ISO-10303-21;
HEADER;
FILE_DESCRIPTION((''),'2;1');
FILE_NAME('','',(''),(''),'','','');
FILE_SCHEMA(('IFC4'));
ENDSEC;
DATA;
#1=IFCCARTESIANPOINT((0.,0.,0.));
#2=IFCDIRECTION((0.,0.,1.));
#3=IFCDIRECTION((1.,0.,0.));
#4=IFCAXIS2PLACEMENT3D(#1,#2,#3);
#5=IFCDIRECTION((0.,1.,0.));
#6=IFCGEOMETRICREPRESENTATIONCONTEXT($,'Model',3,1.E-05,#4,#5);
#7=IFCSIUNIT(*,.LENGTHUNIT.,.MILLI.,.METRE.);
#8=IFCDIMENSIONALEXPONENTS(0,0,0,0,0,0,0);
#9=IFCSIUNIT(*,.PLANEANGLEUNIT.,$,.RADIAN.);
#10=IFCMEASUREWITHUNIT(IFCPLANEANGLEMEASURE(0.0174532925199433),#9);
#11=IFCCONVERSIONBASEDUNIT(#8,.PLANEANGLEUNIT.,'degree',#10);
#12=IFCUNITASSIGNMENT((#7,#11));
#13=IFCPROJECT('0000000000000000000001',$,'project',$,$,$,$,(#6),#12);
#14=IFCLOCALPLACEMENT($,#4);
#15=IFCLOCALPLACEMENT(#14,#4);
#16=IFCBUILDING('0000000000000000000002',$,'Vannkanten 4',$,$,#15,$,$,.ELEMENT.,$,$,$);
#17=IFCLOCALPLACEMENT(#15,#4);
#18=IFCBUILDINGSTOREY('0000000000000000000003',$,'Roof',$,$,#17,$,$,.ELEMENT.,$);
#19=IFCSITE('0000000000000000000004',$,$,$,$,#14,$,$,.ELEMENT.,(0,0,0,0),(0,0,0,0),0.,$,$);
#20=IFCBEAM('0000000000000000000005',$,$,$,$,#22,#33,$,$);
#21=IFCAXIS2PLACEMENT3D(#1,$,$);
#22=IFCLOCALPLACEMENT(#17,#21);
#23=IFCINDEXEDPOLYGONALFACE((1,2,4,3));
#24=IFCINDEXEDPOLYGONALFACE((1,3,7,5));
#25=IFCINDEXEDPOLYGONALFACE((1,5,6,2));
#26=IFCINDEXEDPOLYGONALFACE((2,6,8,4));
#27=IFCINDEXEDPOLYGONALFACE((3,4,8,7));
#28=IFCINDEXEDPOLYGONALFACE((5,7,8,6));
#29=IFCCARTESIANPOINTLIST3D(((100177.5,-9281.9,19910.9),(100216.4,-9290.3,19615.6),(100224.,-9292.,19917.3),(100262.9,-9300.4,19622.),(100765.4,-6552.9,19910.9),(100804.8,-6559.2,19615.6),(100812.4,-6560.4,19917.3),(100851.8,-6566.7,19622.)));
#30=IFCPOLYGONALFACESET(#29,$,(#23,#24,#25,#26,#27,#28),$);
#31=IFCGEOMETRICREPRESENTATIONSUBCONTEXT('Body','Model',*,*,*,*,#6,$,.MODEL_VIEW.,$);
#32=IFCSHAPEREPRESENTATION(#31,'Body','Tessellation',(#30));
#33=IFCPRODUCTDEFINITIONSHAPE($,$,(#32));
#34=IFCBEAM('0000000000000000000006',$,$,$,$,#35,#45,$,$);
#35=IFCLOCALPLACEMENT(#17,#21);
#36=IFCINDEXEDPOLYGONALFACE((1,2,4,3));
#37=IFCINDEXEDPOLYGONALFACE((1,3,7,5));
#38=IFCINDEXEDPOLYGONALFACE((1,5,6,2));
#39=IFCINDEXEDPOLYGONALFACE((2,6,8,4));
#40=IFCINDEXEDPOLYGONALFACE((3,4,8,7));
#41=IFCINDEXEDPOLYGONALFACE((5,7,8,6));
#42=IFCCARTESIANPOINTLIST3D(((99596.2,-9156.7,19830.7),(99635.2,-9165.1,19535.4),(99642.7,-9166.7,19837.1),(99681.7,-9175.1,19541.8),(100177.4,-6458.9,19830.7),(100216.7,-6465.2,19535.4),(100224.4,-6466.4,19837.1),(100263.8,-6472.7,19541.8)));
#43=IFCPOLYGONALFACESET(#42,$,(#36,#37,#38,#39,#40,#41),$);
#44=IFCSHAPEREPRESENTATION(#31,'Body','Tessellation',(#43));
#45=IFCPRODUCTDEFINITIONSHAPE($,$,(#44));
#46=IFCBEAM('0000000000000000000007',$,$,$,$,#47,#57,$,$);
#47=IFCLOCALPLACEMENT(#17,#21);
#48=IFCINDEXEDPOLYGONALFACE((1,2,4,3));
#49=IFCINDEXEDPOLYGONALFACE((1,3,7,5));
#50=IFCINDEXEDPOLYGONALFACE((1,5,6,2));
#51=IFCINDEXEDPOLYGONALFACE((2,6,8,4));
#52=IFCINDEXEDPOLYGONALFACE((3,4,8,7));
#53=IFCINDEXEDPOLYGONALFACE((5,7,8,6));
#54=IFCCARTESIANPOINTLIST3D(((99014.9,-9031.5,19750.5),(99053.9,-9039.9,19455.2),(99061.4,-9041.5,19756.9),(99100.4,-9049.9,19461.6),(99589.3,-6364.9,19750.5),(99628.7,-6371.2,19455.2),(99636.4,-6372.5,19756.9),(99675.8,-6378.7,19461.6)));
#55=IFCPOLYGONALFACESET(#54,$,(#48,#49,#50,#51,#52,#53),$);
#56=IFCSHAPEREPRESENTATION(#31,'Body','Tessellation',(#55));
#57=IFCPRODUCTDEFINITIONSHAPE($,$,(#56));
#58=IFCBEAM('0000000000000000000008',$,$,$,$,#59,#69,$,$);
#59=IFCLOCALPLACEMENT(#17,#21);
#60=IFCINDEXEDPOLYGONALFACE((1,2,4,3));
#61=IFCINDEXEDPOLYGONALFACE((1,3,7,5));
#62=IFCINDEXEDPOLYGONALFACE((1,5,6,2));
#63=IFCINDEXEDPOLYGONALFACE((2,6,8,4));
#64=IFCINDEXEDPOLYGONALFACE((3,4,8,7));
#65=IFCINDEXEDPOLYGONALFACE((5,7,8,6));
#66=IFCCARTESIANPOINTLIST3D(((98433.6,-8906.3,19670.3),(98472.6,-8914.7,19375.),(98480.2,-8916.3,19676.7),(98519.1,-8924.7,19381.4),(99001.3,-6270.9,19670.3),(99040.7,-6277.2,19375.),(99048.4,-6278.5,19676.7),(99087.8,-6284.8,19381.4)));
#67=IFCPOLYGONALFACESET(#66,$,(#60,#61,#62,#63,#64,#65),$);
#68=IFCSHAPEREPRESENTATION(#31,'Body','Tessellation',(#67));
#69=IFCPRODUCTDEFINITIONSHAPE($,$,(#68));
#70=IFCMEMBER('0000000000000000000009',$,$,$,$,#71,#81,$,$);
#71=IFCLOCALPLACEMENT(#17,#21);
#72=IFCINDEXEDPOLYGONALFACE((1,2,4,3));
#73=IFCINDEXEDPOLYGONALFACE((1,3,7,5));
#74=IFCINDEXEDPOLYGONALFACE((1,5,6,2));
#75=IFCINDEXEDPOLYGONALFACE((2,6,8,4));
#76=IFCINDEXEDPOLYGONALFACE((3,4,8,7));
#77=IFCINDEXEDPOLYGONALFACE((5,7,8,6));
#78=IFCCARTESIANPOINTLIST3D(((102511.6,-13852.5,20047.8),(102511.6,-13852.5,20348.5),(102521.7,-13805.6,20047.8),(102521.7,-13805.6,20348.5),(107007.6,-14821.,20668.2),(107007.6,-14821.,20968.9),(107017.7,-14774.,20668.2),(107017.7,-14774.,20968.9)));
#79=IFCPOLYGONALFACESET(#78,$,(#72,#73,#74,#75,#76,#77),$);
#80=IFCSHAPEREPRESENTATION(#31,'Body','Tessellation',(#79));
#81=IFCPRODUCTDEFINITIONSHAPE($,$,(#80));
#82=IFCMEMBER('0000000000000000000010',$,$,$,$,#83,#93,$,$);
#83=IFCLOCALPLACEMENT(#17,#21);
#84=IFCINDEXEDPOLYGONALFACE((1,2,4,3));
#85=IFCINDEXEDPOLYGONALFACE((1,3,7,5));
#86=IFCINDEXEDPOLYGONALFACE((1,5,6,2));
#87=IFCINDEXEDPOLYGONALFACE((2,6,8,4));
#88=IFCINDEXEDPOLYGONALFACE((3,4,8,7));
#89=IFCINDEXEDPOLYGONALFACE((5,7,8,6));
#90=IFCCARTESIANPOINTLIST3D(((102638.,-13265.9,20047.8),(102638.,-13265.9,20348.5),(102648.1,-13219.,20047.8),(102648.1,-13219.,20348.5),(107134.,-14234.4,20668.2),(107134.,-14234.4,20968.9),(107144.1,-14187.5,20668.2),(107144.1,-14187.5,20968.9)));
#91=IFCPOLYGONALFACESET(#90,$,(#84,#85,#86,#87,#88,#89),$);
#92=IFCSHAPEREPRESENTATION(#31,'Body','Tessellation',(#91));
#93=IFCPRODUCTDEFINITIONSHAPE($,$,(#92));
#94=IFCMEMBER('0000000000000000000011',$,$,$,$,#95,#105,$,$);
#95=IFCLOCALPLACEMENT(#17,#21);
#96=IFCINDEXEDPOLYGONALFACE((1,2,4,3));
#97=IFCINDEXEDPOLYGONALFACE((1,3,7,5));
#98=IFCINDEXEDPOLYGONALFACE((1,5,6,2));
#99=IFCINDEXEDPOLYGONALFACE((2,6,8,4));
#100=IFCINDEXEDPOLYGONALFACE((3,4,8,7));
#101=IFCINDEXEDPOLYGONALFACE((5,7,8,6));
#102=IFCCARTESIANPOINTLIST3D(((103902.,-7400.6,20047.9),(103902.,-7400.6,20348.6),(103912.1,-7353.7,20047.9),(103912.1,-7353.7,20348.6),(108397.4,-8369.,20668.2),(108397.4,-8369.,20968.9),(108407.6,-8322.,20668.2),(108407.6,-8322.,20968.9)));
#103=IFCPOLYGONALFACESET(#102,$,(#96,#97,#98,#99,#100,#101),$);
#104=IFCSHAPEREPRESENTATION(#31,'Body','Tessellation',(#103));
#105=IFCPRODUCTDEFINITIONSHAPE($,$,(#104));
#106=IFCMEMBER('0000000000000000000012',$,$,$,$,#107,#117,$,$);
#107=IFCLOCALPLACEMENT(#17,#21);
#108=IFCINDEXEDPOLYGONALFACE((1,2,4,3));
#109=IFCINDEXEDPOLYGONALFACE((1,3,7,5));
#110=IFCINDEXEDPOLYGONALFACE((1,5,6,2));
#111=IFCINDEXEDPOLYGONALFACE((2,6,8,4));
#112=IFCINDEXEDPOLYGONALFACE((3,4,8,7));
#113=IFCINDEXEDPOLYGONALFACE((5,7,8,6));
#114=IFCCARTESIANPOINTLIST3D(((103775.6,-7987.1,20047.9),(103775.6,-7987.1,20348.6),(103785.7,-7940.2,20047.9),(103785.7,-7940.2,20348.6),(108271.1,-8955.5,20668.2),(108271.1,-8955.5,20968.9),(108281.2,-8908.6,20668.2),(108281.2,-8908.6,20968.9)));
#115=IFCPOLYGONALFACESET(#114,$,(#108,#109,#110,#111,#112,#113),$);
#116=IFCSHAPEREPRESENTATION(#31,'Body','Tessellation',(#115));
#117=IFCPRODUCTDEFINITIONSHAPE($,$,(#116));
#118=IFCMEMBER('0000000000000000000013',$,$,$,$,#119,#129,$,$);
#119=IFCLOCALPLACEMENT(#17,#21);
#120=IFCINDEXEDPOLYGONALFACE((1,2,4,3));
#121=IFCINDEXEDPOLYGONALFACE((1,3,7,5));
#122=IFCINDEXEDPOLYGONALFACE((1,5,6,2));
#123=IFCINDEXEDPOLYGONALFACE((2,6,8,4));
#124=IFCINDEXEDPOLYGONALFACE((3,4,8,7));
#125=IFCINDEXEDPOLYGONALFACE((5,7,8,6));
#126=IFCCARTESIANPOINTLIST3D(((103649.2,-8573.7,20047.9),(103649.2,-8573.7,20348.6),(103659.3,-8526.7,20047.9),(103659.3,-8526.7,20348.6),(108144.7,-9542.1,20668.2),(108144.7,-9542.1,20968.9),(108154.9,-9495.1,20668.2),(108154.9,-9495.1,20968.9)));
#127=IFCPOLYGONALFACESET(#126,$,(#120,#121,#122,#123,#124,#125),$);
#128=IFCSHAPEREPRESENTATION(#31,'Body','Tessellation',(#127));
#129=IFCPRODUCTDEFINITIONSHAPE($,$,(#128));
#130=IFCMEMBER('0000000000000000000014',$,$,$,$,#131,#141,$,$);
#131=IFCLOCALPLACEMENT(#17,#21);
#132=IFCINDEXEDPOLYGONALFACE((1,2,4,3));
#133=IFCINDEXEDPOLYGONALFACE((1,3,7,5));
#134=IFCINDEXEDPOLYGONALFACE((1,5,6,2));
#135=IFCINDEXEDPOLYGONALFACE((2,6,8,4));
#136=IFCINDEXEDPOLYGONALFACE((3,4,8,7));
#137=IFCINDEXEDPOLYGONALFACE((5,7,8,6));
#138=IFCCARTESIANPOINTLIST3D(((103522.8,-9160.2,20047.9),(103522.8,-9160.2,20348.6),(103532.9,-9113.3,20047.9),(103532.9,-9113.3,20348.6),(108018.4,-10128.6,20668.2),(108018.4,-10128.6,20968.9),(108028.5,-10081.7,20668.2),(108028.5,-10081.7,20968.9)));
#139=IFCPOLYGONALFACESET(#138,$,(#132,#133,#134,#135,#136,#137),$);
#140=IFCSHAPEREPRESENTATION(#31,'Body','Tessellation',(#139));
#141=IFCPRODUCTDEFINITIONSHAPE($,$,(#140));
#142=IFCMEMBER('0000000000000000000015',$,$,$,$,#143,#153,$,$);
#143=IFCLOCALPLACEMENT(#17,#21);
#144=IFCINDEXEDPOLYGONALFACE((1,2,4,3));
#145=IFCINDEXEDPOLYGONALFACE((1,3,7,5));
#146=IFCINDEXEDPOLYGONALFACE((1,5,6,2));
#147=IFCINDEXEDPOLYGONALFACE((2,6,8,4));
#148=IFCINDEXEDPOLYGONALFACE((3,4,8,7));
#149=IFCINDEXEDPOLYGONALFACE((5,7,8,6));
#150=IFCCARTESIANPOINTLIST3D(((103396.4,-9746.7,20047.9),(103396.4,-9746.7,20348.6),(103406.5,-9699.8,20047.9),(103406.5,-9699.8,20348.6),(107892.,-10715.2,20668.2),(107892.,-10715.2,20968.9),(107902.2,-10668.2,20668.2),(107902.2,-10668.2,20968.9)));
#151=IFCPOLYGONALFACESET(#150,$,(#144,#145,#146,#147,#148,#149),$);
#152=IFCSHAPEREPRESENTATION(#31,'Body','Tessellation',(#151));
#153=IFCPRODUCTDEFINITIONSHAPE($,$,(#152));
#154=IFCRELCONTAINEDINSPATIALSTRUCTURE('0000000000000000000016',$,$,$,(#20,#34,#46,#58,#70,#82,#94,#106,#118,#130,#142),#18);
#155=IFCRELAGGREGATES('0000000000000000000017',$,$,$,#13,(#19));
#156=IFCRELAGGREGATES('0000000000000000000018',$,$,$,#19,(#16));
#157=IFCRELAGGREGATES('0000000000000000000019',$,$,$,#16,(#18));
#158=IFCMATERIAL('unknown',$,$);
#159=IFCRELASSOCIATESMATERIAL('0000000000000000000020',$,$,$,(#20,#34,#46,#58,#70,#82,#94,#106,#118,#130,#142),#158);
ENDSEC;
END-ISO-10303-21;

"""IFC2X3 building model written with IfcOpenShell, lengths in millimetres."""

from ifc_helpers import new_model, entity, si_unit, converted_unit, direction, frame, origin_with_axes, place, context, subcontext, project, spatial, polyline, segment, composite_curve, outline, extrude, clip, halfspace, material, element, save


model = new_model("IFC2X3")

# Units and contexts
model_context = context("Model", 3, precision=1e-05, world=origin_with_axes(), true_north=direction((0.0, 1.0, 0.0)))
body_context = subcontext(model_context, "Body", "Model", "MODEL_VIEW")
ifc_project = project(units=[si_unit("LENGTHUNIT", "METRE", prefix="MILLI"), converted_unit("PLANEANGLEUNIT", "degree", entity("IfcPlaneAngleMeasure", 0.0174532925199433), si_unit("PLANEANGLEUNIT", "RADIAN"), dimensions=[0, 0, 0, 0, 0, 0, 0])], contexts=[model_context])

# Site, building, storey
site_placement = place(None, origin_with_axes())
site = spatial("IfcSite", under=ifc_project, at=site_placement, CompositionType="ELEMENT", RefLatitude=(0, 0, 0, 0), RefLongitude=(0, 0, 0, 0), RefElevation=0.0)
building_placement = place(site_placement, origin_with_axes())
building = spatial("IfcBuilding", under=site, at=building_placement, Name="Vannkanten 4", CompositionType="ELEMENT")
storey_placement = place(building_placement, origin_with_axes())
storey = spatial("IfcBuildingStorey", under=building, at=storey_placement, Name="Roof", CompositionType="ELEMENT")

# Shared definitions
ifc_material = material(Name="unknown")

# Beams
beam_1_placement = place(storey_placement, frame((100220.2, -9291.1, 19766.5), z_axis=(0.210582, 0.977576, 0.0), x_axis=(-0.968803, 0.208692, -0.133675)))
element("IfcBeam", 1, at=beam_1_placement, inside=storey, material=ifc_material, context=body_context, shape_type="Clipping", body=[
    clip(extrude(outline(composite_curve([segment(polyline([(-24.0, -149.0), (-24.0, 149.0), (24.0, 149.0), (24.0, -149.0), (-24.0, -149.0)]), True, "CONTINUOUS")], self_intersect=False)), frame((0.0, 0.0, 0.0), z_axis=(0.0, 0.0, 1.0), x_axis=(1.0, 0.0, 0.0)), (0.0, 0.0, 1.0), 4194.5), halfspace(frame((-24.0, -149.0, 2796.3), z_axis=(-0.053168, -0.007172, -0.99856), x_axis=(-0.998586, 0.0, 0.053169)), True)),
])
beam_2_placement = place(storey_placement, frame((99638.9, -9165.9, 19686.2), z_axis=(0.210582, 0.977576, 0.0), x_axis=(-0.968803, 0.208692, -0.133675)))
element("IfcBeam", 2, at=beam_2_placement, inside=storey, material=ifc_material, context=body_context, shape_type="Clipping", body=[
    clip(extrude(outline(composite_curve([segment(polyline([(-24.0, -149.0), (-24.0, 149.0), (24.0, 149.0), (24.0, -149.0), (-24.0, -149.0)]), True, "CONTINUOUS")], self_intersect=False)), frame((0.0, 0.0, 0.0), z_axis=(0.0, 0.0, 1.0), x_axis=(1.0, 0.0, 0.0)), (0.0, 0.0, 1.0), 4146.6), halfspace(frame((-24.0, -149.0, 2764.4), z_axis=(-0.053168, -0.007172, -0.99856), x_axis=(-0.998586, 0.0, 0.053169)), True)),
])
beam_3_placement = place(storey_placement, frame((99057.7, -9040.7, 19606.0), z_axis=(0.210582, 0.977576, 0.0), x_axis=(-0.968803, 0.208692, -0.133675)))
element("IfcBeam", 3, at=beam_3_placement, inside=storey, material=ifc_material, context=body_context, shape_type="Clipping", body=[
    clip(extrude(outline(composite_curve([segment(polyline([(-24.0, -149.0), (-24.0, 149.0), (24.0, 149.0), (24.0, -149.0), (-24.0, -149.0)]), True, "CONTINUOUS")], self_intersect=False)), frame((0.0, 0.0, 0.0), z_axis=(0.0, 0.0, 1.0), x_axis=(1.0, 0.0, 0.0)), (0.0, 0.0, 1.0), 4098.7), halfspace(frame((-24.0, -149.0, 2732.4), z_axis=(-0.053168, -0.007172, -0.99856), x_axis=(-0.998586, 0.0, 0.053169)), True)),
])
beam_4_placement = place(storey_placement, frame((98476.4, -8915.5, 19525.8), z_axis=(0.210582, 0.977576, 0.0), x_axis=(-0.968803, 0.208692, -0.133675)))
element("IfcBeam", 4, at=beam_4_placement, inside=storey, material=ifc_material, context=body_context, shape_type="Clipping", body=[
    clip(extrude(outline(composite_curve([segment(polyline([(-24.0, -149.0), (-24.0, 149.0), (24.0, 149.0), (24.0, -149.0), (-24.0, -149.0)]), True, "CONTINUOUS")], self_intersect=False)), frame((0.0, 0.0, 0.0), z_axis=(0.0, 0.0, 1.0), x_axis=(1.0, 0.0, 0.0)), (0.0, 0.0, 1.0), 4050.7), halfspace(frame((-24.0, -149.0, 2700.5), z_axis=(-0.053168, -0.007172, -0.99856), x_axis=(-0.998586, 0.0, 0.053169)), True)),
])

# Members
member_1_placement = place(storey_placement, frame((102516.6, -13829.0, 20198.2), z_axis=(0.968803, -0.208692, 0.133675), x_axis=(0.210582, 0.977576, 0.0)))
element("IfcMember", 5, at=member_1_placement, inside=storey, material=ifc_material, context=body_context, shape_type="Clipping", body=[
    clip(clip(extrude(outline(composite_curve([segment(polyline([(-24.0, -149.0), (-24.0, 149.0), (24.0, 149.0), (24.0, -149.0), (-24.0, -149.0)]), True, "CONTINUOUS")], self_intersect=False)), frame((0.0, 0.0, -2360.6), z_axis=(0.0, 0.0, 1.0), x_axis=(1.0, 0.0, 0.0)), (0.0, 0.0, 1.0), 9362.0), halfspace(frame((-24.0, 149.0, 20.1), z_axis=(-0.000083, -0.133675, 0.991025), x_axis=(0.0, 0.991025, 0.133675)), True)), halfspace(frame((24.0, 149.0, 4660.9), z_axis=(0.0, 0.133675, -0.991025), x_axis=(0.0, -0.991025, -0.133675)), True)),
])
member_2_placement = place(storey_placement, frame((102643.0, -13242.5, 20198.2), z_axis=(0.968803, -0.208692, 0.133675), x_axis=(0.210582, 0.977576, 0.0)))
element("IfcMember", 6, at=member_2_placement, inside=storey, material=ifc_material, context=body_context, shape_type="Clipping", body=[
    clip(clip(extrude(outline(composite_curve([segment(polyline([(-24.0, -149.0), (-24.0, 149.0), (24.0, 149.0), (24.0, -149.0), (-24.0, -149.0)]), True, "CONTINUOUS")], self_intersect=False)), frame((0.0, 0.0, -2360.6), z_axis=(0.0, 0.0, 1.0), x_axis=(1.0, 0.0, 0.0)), (0.0, 0.0, 1.0), 9361.9), halfspace(frame((-24.0, 149.0, 20.1), z_axis=(-0.000083, -0.133675, 0.991025), x_axis=(0.0, 0.991025, 0.133675)), True)), halfspace(frame((24.0, 149.0, 4660.8), z_axis=(0.0, 0.133675, -0.991025), x_axis=(0.0, -0.991025, -0.133675)), True)),
])
member_3_placement = place(storey_placement, frame((103907.0, -7377.1, 20198.2), z_axis=(0.968803, -0.208692, 0.133675), x_axis=(0.210582, 0.977576, 0.0)))
element("IfcMember", 7, at=member_3_placement, inside=storey, material=ifc_material, context=body_context, shape_type="Clipping", body=[
    clip(clip(extrude(outline(composite_curve([segment(polyline([(-24.0, -149.0), (-24.0, 149.0), (24.0, 149.0), (24.0, -149.0), (-24.0, -149.0)]), True, "CONTINUOUS")], self_intersect=False)), frame((0.0, 0.0, -2360.3), z_axis=(0.0, 0.0, 1.0), x_axis=(1.0, 0.0, 0.0)), (0.0, 0.0, 1.0), 9360.9), halfspace(frame((-24.0, 149.0, 20.1), z_axis=(-0.000083, -0.133675, 0.991025), x_axis=(0.0, 0.991025, 0.133675)), True)), halfspace(frame((24.0, 149.0, 4660.3), z_axis=(0.0, 0.133675, -0.991025), x_axis=(0.0, -0.991025, -0.133675)), True)),
])
member_4_placement = place(storey_placement, frame((103780.6, -7963.7, 20198.2), z_axis=(0.968803, -0.208692, 0.133675), x_axis=(0.210582, 0.977576, 0.0)))
element("IfcMember", 8, at=member_4_placement, inside=storey, material=ifc_material, context=body_context, shape_type="Clipping", body=[
    clip(clip(extrude(outline(composite_curve([segment(polyline([(-24.0, -149.0), (-24.0, 149.0), (24.0, 149.0), (24.0, -149.0), (-24.0, -149.0)]), True, "CONTINUOUS")], self_intersect=False)), frame((0.0, 0.0, -2360.3), z_axis=(0.0, 0.0, 1.0), x_axis=(1.0, 0.0, 0.0)), (0.0, 0.0, 1.0), 9361.0), halfspace(frame((-24.0, 149.0, 20.1), z_axis=(-0.000083, -0.133675, 0.991025), x_axis=(0.0, 0.991025, 0.133675)), True)), halfspace(frame((24.0, 149.0, 4660.4), z_axis=(0.0, 0.133675, -0.991025), x_axis=(0.0, -0.991025, -0.133675)), True)),
])
member_5_placement = place(storey_placement, frame((103654.2, -8550.2, 20198.2), z_axis=(0.968803, -0.208692, 0.133675), x_axis=(0.210582, 0.977576, 0.0)))
element("IfcMember", 9, at=member_5_placement, inside=storey, material=ifc_material, context=body_context, shape_type="Clipping", body=[
    clip(clip(extrude(outline(composite_curve([segment(polyline([(-24.0, -149.0), (-24.0, 149.0), (24.0, 149.0), (24.0, -149.0), (-24.0, -149.0)]), True, "CONTINUOUS")], self_intersect=False)), frame((0.0, 0.0, -2360.4), z_axis=(0.0, 0.0, 1.0), x_axis=(1.0, 0.0, 0.0)), (0.0, 0.0, 1.0), 9361.1), halfspace(frame((-24.0, 149.0, 20.1), z_axis=(-0.000083, -0.133675, 0.991025), x_axis=(0.0, 0.991025, 0.133675)), True)), halfspace(frame((24.0, 149.0, 4660.4), z_axis=(0.0, 0.133675, -0.991025), x_axis=(0.0, -0.991025, -0.133675)), True)),
])
member_6_placement = place(storey_placement, frame((103527.8, -9136.7, 20198.2), z_axis=(0.968803, -0.208692, 0.133675), x_axis=(0.210582, 0.977576, 0.0)))
element("IfcMember", 10, at=member_6_placement, inside=storey, material=ifc_material, context=body_context, shape_type="Clipping", body=[
    clip(clip(extrude(outline(composite_curve([segment(polyline([(-24.0, -149.0), (-24.0, 149.0), (24.0, 149.0), (24.0, -149.0), (-24.0, -149.0)]), True, "CONTINUOUS")], self_intersect=False)), frame((0.0, 0.0, -2360.4), z_axis=(0.0, 0.0, 1.0), x_axis=(1.0, 0.0, 0.0)), (0.0, 0.0, 1.0), 9361.2), halfspace(frame((-24.0, 149.0, 20.1), z_axis=(-0.000083, -0.133675, 0.991025), x_axis=(0.0, 0.991025, 0.133675)), True)), halfspace(frame((24.0, 149.0, 4660.5), z_axis=(0.0, 0.133675, -0.991025), x_axis=(0.0, -0.991025, -0.133675)), True)),
])
member_7_placement = place(storey_placement, frame((103401.4, -9723.3, 20198.2), z_axis=(0.968803, -0.208692, 0.133675), x_axis=(0.210582, 0.977576, 0.0)))
element("IfcMember", 11, at=member_7_placement, inside=storey, material=ifc_material, context=body_context, shape_type="Clipping", body=[
    clip(clip(extrude(outline(composite_curve([segment(polyline([(-24.0, -149.0), (-24.0, 149.0), (24.0, 149.0), (24.0, -149.0), (-24.0, -149.0)]), True, "CONTINUOUS")], self_intersect=False)), frame((0.0, 0.0, -2360.4), z_axis=(0.0, 0.0, 1.0), x_axis=(1.0, 0.0, 0.0)), (0.0, 0.0, 1.0), 9361.3), halfspace(frame((-24.0, 149.0, 20.1), z_axis=(-0.000083, -0.133675, 0.991025), x_axis=(0.0, 0.991025, 0.133675)), True)), halfspace(frame((24.0, 149.0, 4660.5), z_axis=(0.0, 0.133675, -0.991025), x_axis=(0.0, -0.991025, -0.133675)), True)),
])

save(model, "model.ifc")
